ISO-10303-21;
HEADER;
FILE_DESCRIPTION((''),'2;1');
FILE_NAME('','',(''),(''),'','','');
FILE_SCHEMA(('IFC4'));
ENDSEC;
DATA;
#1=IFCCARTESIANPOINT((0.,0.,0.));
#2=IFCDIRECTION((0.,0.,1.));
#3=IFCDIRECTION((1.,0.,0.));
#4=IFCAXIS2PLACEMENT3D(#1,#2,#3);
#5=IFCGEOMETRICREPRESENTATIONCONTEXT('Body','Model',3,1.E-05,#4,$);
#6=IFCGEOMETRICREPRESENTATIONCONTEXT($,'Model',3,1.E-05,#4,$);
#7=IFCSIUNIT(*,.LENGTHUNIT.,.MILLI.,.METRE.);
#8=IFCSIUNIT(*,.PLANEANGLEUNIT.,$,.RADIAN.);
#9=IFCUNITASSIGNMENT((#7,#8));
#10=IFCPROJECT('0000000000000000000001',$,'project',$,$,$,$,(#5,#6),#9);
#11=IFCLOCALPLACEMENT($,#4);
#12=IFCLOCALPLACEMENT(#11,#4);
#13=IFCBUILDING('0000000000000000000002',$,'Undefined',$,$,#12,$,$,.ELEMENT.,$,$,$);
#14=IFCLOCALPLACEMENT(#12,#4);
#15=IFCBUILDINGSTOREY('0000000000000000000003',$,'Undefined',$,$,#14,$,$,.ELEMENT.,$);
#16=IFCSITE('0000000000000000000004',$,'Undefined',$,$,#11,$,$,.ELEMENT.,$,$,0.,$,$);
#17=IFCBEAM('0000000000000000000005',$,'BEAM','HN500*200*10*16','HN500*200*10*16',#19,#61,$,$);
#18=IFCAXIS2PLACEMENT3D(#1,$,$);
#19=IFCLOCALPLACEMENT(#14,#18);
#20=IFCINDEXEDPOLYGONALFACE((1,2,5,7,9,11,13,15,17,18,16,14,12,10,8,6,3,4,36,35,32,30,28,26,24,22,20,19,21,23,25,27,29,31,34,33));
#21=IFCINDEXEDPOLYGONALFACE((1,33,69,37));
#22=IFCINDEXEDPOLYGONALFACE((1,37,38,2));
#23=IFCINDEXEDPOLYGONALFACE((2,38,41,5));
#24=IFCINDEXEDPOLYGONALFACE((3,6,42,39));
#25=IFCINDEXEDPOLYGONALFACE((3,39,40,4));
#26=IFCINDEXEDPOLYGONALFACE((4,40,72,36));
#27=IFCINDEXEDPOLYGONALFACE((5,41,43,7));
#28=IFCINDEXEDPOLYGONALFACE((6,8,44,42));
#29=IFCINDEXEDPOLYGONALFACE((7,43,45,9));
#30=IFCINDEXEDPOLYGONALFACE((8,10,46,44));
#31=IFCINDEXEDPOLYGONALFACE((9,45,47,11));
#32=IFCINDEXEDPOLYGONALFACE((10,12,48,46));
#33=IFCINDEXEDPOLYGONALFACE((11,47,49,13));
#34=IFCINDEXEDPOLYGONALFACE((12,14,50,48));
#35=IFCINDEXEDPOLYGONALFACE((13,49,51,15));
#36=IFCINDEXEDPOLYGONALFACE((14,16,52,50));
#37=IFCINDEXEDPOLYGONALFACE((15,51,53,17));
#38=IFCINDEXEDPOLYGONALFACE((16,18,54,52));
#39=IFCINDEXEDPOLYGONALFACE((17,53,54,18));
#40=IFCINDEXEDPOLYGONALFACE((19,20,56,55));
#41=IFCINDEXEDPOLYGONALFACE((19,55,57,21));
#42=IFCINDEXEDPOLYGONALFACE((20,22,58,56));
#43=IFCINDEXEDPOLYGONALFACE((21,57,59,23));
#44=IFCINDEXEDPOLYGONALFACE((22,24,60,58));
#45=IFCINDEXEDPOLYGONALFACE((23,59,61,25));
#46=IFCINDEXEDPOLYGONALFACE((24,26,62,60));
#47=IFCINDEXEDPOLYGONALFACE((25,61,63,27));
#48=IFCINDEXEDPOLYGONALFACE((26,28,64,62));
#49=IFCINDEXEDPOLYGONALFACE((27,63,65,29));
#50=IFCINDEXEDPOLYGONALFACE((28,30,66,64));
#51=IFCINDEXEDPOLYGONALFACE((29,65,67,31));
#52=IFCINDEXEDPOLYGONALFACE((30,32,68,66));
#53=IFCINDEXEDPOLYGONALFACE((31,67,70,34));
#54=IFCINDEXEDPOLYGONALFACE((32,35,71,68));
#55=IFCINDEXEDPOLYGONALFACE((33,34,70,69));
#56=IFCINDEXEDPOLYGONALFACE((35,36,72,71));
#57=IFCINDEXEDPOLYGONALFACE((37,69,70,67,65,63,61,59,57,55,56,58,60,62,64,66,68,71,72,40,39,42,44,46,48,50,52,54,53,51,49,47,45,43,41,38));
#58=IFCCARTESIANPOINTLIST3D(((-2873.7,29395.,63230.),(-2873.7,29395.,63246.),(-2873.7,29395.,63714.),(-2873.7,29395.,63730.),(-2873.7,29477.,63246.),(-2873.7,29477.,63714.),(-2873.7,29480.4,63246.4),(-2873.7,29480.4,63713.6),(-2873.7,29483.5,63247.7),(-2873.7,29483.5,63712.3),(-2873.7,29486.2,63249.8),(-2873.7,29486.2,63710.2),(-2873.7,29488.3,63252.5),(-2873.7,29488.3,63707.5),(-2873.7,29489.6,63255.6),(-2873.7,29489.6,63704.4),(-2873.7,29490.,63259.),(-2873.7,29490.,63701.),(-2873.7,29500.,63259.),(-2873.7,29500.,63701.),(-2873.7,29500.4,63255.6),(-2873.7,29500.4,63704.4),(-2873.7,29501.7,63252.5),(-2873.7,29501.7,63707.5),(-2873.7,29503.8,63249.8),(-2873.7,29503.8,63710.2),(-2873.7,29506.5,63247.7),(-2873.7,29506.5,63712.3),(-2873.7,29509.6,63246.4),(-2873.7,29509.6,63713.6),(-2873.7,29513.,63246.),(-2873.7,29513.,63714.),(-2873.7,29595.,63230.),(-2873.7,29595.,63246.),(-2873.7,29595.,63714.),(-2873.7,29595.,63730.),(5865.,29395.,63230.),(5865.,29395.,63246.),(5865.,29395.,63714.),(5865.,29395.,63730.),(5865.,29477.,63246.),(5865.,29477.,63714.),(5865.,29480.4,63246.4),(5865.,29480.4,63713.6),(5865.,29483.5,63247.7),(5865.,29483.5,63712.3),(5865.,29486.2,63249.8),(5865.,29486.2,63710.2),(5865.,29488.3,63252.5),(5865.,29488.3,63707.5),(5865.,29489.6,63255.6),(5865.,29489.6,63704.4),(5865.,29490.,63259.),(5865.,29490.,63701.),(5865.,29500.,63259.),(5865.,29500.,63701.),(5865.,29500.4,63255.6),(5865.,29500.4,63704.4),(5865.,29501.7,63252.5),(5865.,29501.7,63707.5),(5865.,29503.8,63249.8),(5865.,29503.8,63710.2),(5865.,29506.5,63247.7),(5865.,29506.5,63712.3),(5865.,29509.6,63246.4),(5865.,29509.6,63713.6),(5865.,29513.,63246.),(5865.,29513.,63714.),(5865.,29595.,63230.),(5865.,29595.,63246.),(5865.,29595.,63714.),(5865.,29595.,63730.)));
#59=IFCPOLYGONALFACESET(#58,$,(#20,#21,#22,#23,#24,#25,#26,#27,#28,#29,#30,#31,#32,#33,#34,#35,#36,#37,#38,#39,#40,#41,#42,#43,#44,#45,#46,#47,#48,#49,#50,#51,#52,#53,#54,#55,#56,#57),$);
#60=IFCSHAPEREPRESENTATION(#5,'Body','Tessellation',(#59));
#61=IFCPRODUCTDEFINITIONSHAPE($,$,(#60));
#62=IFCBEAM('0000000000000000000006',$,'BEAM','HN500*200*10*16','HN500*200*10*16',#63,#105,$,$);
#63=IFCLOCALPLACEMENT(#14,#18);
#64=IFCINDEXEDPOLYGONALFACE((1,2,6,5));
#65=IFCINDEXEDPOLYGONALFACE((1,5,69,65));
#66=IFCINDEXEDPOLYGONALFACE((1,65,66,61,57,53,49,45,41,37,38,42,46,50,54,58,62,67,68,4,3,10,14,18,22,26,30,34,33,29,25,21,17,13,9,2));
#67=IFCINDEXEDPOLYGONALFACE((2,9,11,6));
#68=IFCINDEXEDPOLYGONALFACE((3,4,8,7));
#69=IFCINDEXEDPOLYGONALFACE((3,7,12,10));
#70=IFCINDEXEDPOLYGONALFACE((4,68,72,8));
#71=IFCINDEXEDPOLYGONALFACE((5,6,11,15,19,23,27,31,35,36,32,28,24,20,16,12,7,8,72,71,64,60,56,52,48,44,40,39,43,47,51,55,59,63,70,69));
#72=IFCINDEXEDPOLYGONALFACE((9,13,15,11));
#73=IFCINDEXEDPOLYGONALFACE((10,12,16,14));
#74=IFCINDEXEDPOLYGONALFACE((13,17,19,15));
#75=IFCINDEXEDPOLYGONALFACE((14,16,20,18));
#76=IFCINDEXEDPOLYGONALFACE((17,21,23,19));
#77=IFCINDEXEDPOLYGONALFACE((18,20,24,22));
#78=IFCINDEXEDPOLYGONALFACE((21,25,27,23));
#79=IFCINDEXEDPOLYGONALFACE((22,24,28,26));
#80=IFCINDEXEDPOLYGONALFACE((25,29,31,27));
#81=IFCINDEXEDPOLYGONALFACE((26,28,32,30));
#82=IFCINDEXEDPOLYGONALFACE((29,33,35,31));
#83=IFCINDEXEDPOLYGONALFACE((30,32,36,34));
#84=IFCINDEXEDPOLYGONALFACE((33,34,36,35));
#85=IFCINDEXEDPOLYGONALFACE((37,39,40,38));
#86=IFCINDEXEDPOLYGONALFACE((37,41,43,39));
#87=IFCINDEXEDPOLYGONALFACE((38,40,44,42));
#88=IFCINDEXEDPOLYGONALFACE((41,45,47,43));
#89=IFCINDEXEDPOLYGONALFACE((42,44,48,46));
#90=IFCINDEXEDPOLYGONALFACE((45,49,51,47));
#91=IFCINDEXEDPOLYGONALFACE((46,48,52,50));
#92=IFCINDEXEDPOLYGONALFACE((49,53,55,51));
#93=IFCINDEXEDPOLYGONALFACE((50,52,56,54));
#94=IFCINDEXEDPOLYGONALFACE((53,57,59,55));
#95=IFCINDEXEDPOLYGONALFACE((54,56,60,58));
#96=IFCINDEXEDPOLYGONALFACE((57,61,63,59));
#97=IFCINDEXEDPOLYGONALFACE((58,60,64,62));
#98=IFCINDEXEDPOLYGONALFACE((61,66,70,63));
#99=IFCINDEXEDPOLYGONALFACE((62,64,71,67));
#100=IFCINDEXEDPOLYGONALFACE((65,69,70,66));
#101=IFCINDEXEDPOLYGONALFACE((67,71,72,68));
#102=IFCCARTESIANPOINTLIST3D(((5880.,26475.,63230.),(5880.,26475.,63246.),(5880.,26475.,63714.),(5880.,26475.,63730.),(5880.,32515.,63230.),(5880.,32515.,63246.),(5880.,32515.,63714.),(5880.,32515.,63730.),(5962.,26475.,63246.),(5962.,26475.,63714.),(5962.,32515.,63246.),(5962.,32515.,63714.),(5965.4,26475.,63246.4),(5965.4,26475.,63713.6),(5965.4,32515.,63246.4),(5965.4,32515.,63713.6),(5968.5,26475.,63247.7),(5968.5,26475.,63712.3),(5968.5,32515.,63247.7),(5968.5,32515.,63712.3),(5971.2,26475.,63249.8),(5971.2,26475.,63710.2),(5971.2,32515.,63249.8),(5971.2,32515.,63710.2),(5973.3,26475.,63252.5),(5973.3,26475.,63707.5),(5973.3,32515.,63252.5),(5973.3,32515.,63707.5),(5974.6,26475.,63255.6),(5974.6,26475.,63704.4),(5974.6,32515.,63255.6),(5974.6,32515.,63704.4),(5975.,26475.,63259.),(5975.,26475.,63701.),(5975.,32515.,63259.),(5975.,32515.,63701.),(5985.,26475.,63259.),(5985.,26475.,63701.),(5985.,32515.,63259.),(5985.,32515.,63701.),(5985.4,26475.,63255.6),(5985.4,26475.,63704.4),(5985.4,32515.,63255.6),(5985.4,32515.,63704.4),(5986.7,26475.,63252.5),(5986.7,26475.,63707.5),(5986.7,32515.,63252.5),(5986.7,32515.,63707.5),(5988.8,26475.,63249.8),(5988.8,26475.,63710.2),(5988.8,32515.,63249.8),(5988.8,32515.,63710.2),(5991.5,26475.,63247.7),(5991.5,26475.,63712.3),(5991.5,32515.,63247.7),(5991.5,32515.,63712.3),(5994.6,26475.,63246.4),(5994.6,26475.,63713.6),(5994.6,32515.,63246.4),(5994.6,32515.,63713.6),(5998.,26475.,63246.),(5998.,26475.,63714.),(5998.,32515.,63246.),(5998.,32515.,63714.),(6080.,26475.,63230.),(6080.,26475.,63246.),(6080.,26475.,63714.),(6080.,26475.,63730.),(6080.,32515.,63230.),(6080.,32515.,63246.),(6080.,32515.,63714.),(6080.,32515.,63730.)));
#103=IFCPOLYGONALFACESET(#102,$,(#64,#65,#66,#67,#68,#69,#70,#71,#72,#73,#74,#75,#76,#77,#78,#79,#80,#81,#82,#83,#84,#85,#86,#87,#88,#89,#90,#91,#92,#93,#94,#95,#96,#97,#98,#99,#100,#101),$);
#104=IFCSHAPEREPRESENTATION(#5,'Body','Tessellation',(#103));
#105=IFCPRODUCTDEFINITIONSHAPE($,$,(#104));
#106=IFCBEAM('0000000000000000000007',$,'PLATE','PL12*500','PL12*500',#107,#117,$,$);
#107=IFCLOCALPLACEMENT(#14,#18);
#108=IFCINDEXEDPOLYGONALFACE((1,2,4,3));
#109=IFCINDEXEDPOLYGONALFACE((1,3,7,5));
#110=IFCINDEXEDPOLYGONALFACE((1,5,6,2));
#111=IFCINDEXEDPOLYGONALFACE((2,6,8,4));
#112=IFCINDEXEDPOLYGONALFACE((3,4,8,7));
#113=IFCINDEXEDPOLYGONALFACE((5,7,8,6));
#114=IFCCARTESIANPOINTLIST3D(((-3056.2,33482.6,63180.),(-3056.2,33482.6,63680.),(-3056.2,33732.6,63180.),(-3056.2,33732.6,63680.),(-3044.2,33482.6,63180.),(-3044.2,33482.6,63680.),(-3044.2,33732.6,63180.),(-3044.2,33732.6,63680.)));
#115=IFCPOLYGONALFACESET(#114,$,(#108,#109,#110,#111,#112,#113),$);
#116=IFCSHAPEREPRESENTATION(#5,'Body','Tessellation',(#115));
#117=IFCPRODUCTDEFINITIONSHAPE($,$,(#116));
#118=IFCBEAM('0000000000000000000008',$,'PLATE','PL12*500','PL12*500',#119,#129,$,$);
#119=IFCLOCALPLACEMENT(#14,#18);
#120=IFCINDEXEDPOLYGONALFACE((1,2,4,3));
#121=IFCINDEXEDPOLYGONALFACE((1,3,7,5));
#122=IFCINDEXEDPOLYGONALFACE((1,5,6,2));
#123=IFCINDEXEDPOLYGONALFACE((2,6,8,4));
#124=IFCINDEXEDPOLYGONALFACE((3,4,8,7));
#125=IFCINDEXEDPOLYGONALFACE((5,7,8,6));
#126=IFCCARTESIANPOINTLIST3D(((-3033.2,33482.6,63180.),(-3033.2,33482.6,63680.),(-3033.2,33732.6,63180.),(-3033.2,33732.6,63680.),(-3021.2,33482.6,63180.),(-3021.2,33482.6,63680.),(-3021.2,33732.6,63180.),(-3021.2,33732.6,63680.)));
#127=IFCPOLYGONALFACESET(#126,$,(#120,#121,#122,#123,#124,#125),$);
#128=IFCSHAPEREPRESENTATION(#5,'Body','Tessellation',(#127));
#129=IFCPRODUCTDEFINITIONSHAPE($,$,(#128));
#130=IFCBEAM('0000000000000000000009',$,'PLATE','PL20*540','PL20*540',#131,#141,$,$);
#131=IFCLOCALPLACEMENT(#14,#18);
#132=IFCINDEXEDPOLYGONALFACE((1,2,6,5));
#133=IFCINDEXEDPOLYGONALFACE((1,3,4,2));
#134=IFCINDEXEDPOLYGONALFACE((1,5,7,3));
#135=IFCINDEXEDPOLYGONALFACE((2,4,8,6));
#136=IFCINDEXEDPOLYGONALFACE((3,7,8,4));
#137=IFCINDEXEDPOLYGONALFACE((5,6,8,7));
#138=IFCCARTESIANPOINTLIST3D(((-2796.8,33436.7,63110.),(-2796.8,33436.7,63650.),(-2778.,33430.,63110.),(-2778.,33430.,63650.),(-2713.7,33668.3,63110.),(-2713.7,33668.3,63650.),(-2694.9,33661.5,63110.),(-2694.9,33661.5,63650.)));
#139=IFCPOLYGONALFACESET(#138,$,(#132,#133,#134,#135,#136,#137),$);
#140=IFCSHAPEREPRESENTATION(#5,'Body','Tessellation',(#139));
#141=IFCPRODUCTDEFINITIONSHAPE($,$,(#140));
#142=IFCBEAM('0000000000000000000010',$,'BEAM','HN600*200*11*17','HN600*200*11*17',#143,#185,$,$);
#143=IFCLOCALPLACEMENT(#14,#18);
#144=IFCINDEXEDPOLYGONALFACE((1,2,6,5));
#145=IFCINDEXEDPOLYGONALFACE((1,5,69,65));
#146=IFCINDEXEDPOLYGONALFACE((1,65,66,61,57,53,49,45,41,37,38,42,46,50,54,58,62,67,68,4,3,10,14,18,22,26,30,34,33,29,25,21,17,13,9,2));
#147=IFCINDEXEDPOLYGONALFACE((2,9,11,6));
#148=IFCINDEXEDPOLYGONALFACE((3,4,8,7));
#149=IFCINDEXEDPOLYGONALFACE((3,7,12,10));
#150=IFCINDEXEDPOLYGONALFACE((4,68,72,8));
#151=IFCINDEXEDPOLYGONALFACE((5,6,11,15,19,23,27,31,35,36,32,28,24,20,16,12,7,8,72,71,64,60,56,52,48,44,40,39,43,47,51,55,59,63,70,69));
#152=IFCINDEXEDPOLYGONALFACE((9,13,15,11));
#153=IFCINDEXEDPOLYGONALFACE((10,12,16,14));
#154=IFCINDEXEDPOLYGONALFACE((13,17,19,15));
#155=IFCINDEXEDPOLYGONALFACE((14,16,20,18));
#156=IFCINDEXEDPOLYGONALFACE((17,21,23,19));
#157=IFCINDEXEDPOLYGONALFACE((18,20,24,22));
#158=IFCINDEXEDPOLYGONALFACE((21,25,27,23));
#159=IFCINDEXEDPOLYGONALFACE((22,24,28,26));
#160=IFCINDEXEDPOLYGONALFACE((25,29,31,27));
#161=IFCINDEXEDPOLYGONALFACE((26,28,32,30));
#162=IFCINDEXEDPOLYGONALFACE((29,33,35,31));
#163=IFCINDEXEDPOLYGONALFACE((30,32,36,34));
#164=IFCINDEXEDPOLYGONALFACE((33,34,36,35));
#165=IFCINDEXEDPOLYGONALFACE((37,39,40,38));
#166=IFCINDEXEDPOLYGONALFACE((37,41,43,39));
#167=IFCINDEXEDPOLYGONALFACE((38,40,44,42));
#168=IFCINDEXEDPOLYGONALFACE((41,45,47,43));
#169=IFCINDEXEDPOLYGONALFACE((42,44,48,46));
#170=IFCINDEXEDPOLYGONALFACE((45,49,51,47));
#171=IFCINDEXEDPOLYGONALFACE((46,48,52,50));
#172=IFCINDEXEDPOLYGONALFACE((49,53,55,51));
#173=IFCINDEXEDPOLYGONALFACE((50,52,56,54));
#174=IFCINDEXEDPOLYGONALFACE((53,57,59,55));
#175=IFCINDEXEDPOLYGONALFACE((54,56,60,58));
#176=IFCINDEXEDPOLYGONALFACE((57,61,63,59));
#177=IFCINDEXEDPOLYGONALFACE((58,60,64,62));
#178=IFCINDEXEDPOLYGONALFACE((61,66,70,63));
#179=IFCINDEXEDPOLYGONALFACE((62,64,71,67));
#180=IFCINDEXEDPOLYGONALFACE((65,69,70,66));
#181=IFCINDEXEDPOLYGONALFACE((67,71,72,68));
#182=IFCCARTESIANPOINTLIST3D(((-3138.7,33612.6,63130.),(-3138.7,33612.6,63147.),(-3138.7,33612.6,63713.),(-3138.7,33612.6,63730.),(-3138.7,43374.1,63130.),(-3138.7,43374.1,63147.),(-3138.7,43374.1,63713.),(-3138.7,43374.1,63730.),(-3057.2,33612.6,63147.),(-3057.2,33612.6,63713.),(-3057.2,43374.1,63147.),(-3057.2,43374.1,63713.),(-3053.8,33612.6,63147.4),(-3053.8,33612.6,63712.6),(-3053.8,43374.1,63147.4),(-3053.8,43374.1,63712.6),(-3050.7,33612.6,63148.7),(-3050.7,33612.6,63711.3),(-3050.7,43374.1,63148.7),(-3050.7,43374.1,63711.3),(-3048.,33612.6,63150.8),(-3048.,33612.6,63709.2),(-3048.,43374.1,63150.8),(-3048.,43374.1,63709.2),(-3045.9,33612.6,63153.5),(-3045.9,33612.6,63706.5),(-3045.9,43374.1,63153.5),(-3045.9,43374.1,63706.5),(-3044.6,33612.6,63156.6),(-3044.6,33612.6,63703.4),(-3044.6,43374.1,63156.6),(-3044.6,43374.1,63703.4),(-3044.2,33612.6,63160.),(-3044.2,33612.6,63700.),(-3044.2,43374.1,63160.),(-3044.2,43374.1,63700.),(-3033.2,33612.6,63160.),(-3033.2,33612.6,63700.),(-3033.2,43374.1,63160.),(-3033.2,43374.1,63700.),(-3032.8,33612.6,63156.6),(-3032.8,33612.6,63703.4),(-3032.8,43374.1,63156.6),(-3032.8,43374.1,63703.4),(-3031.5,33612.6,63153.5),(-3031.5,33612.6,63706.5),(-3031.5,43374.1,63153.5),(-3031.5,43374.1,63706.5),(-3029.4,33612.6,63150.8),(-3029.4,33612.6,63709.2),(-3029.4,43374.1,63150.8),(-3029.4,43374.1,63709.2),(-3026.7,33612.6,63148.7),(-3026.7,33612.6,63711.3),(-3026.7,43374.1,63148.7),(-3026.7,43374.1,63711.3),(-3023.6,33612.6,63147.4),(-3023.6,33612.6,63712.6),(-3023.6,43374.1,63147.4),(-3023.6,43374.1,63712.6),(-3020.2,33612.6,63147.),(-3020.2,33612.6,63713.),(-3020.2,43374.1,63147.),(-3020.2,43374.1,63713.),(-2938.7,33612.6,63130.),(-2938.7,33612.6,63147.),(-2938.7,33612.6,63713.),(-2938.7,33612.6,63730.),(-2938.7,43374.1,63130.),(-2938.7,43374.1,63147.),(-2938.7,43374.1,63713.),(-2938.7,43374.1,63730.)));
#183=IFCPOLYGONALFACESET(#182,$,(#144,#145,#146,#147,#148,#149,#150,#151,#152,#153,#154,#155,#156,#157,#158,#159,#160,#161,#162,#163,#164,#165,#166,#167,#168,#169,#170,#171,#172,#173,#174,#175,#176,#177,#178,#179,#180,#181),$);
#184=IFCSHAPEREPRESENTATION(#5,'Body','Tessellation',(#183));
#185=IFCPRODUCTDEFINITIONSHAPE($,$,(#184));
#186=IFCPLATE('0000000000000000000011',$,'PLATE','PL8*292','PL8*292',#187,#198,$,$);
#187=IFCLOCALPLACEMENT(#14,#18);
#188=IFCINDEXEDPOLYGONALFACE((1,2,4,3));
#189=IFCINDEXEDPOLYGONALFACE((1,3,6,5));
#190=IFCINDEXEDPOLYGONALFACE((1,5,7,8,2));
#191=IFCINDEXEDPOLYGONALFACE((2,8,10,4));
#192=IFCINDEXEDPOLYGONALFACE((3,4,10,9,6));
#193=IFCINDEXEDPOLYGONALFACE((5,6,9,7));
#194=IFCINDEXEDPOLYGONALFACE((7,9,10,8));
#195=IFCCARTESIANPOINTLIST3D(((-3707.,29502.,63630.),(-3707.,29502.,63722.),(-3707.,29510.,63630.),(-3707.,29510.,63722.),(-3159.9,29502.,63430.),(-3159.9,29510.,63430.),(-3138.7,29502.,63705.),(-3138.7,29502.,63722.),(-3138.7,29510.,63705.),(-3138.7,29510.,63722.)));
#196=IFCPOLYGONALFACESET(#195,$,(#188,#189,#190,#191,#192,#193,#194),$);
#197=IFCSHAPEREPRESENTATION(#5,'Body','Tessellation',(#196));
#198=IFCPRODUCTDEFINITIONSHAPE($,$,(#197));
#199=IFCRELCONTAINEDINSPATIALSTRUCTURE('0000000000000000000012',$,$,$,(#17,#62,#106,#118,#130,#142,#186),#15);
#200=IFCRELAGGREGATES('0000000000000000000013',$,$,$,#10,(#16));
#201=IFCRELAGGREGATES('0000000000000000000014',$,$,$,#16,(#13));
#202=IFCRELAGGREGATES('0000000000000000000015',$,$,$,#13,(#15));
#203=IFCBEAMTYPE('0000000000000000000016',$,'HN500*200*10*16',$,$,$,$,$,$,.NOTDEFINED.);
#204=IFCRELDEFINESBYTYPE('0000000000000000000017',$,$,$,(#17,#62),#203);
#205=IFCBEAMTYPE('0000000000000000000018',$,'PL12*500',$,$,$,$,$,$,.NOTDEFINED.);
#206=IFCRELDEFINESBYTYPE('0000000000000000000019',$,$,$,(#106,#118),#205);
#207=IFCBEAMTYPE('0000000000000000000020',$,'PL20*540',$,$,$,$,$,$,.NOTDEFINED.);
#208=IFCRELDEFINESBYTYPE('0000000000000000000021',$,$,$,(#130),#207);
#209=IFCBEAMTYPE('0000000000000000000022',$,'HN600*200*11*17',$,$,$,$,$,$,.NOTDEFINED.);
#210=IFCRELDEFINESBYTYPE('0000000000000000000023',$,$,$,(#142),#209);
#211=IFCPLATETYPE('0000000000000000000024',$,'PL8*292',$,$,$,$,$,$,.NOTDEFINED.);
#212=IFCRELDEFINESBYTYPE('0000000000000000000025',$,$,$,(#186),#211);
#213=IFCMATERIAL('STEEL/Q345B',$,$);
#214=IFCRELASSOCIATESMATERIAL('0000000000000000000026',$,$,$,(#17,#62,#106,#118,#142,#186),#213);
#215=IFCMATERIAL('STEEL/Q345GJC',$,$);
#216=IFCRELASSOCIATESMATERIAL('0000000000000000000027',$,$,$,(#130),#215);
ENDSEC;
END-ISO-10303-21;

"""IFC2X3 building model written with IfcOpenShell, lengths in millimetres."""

from ifc_helpers import new_model, si_unit, frame, origin_with_axes, origin_2d_with_axis, place, context, project, spatial, polyline, rectangle, i_section, outline, extrude, material, type_object, element, save


model = new_model("IFC2X3")

# Units and contexts
model_context_1 = context("Model", 3, precision=1e-05, world=origin_with_axes(), identifier="Body")
model_context_2 = context("Model", 3, precision=1e-05, world=origin_with_axes())
ifc_project = project(units=[si_unit("LENGTHUNIT", "METRE", prefix="MILLI"), si_unit("PLANEANGLEUNIT", "RADIAN")], contexts=[model_context_1, model_context_2])

# Site, building, storey
site_placement = place(None, origin_with_axes())
site = spatial("IfcSite", under=ifc_project, at=site_placement, Name="Undefined", CompositionType="ELEMENT", RefElevation=0.0)
building_placement = place(site_placement, origin_with_axes())
building = spatial("IfcBuilding", under=site, at=building_placement, Name="Undefined", CompositionType="ELEMENT")
storey_placement = place(building_placement, origin_with_axes())
storey = spatial("IfcBuildingStorey", under=building, at=storey_placement, Name="Undefined", CompositionType="ELEMENT")

# Shared definitions
ifc_material_1 = material(Name="STEEL/Q345B")

# Beams
beam_type_1 = type_object("IfcBeamType", Name="HN500*200*10*16", PredefinedType="NOTDEFINED")
beam_1_placement = place(storey_placement, frame((5980.0, 29495.0, 63480.0), z_axis=(0.0, 0.0, 1.0), x_axis=(-1.0, 0.0, 0.0)))
element("IfcBeam", 1, at=beam_1_placement, inside=storey, type_object=beam_type_1, material=ifc_material_1, Name="BEAM", Description="HN500*200*10*16", ObjectType="HN500*200*10*16", context=model_context_1, shape_type="SweptSolid", body=[
    extrude(i_section(OverallWidth=200.0, OverallDepth=500.0, WebThickness=10.0, FlangeThickness=16.0, FilletRadius=13.0, at=origin_2d_with_axis()), frame((8853.7, 0.0, 0.0), z_axis=(-1.0, 0.0, 0.0), x_axis=(0.0, -1.0, 0.0)), (0.0, 0.0, 1.0), 8738.7),
])
beam_2_placement = place(storey_placement, frame((5980.0, 26310.0, 63480.0), z_axis=(0.0, 0.0, 1.0), x_axis=(0.0, 1.0, 0.0)))
element("IfcBeam", 2, at=beam_2_placement, inside=storey, type_object=beam_type_1, material=ifc_material_1, Name="BEAM", Description="HN500*200*10*16", ObjectType="HN500*200*10*16", context=model_context_1, shape_type="SweptSolid", body=[
    extrude(i_section(OverallWidth=200.0, OverallDepth=500.0, WebThickness=10.0, FlangeThickness=16.0, FilletRadius=13.0, at=origin_2d_with_axis()), frame((6205.0, 0.0, 0.0), z_axis=(-1.0, 0.0, 0.0), x_axis=(0.0, -1.0, 0.0)), (0.0, 0.0, 1.0), 6040.0),
])
beam_type_2 = type_object("IfcBeamType", Name="PL12*500", PredefinedType="NOTDEFINED")
for number, where, z_axis, x_axis, name in (
    (3, (-3050.2, 33482.6, 63430.0), (0.0, 0.0, 1.0), (0.0, 1.0, 0.0), "PLATE"),
    (4, (-3027.2, 33482.6, 63430.0), (0.0, 0.0, 1.0), (0.0, 1.0, 0.0), "PLATE"),
):
    element("IfcBeam", number, at=place(storey_placement, frame(where, z_axis=z_axis, x_axis=x_axis)), inside=storey, type_object=beam_type_2, material=ifc_material_1, Name=name, Description="PL12*500", ObjectType="PL12*500", context=model_context_1, shape_type="SweptSolid", body=[
        extrude(rectangle(XDim=12.0, YDim=500.0, at=origin_2d_with_axis()), frame((250.0, 0.0, 0.0), z_axis=(-1.0, 0.0, 0.0), x_axis=(0.0, -1.0, 0.0)), (0.0, 0.0, 1.0), 250.0),
    ])
ifc_material_2 = material(Name="STEEL/Q345GJC")
beam_type_3 = type_object("IfcBeamType", Name="PL20*540", PredefinedType="NOTDEFINED")
beam_3_placement = place(storey_placement, frame((-2787.4, 33433.4, 63380.0), z_axis=(0.0, 0.0, 1.0), x_axis=(0.337816, 0.941212, 0.0)))
element("IfcBeam", 5, at=beam_3_placement, inside=storey, type_object=beam_type_3, material=ifc_material_2, Name="PLATE", Description="PL20*540", ObjectType="PL20*540", context=model_context_1, shape_type="SweptSolid", body=[
    extrude(rectangle(XDim=20.0, YDim=540.0, at=origin_2d_with_axis()), frame((246.0, 0.0, 0.0), z_axis=(-1.0, 0.0, 0.0), x_axis=(0.0, -1.0, 0.0)), (0.0, 0.0, 1.0), 246.0),
])
beam_type_4 = type_object("IfcBeamType", Name="HN600*200*11*17", PredefinedType="NOTDEFINED")
beam_4_placement = place(storey_placement, frame((-3038.7, 32680.0, 63430.0), z_axis=(0.0, 0.0, 1.0), x_axis=(0.0, 1.0, 0.0)))
element("IfcBeam", 6, at=beam_4_placement, inside=storey, type_object=beam_type_4, material=ifc_material_1, Name="BEAM", Description="HN600*200*11*17", ObjectType="HN600*200*11*17", context=model_context_1, shape_type="SweptSolid", body=[
    extrude(i_section(OverallWidth=200.0, OverallDepth=600.0, WebThickness=11.0, FlangeThickness=17.0, FilletRadius=13.0, at=origin_2d_with_axis()), frame((10694.1, 0.0, 0.0), z_axis=(-1.0, 0.0, 0.0), x_axis=(0.0, -1.0, 0.0)), (0.0, 0.0, 1.0), 9761.5),
])

# Plate
plate_type_1 = type_object("IfcPlateType", Name="PL8*292", PredefinedType="NOTDEFINED")
for number, where, z_axis, x_axis, name in (
    (7, (-3138.7, 29506.0, 63722.0), (0.0, 1.0, 0.0), (0.0, 0.0, -1.0), "PLATE"),
):
    element("IfcPlate", number, at=place(storey_placement, frame(where, z_axis=z_axis, x_axis=x_axis)), inside=storey, type_object=plate_type_1, material=ifc_material_1, Name=name, Description="PL8*292", ObjectType="PL8*292", context=model_context_1, shape_type="SweptSolid", body=[
        extrude(outline(polyline([(0.0, 0.0), (17.0, 0.0), (292.0, 21.2), (92.0, 568.3), (0.0, 568.3), (0.0, 0.0)])), frame((0.0, 0.0, -4.0), z_axis=(0.0, 0.0, 1.0), x_axis=(1.0, 0.0, 0.0)), (0.0, 0.0, 1.0), 8.0),
    ])

save(model, "model.ifc")
